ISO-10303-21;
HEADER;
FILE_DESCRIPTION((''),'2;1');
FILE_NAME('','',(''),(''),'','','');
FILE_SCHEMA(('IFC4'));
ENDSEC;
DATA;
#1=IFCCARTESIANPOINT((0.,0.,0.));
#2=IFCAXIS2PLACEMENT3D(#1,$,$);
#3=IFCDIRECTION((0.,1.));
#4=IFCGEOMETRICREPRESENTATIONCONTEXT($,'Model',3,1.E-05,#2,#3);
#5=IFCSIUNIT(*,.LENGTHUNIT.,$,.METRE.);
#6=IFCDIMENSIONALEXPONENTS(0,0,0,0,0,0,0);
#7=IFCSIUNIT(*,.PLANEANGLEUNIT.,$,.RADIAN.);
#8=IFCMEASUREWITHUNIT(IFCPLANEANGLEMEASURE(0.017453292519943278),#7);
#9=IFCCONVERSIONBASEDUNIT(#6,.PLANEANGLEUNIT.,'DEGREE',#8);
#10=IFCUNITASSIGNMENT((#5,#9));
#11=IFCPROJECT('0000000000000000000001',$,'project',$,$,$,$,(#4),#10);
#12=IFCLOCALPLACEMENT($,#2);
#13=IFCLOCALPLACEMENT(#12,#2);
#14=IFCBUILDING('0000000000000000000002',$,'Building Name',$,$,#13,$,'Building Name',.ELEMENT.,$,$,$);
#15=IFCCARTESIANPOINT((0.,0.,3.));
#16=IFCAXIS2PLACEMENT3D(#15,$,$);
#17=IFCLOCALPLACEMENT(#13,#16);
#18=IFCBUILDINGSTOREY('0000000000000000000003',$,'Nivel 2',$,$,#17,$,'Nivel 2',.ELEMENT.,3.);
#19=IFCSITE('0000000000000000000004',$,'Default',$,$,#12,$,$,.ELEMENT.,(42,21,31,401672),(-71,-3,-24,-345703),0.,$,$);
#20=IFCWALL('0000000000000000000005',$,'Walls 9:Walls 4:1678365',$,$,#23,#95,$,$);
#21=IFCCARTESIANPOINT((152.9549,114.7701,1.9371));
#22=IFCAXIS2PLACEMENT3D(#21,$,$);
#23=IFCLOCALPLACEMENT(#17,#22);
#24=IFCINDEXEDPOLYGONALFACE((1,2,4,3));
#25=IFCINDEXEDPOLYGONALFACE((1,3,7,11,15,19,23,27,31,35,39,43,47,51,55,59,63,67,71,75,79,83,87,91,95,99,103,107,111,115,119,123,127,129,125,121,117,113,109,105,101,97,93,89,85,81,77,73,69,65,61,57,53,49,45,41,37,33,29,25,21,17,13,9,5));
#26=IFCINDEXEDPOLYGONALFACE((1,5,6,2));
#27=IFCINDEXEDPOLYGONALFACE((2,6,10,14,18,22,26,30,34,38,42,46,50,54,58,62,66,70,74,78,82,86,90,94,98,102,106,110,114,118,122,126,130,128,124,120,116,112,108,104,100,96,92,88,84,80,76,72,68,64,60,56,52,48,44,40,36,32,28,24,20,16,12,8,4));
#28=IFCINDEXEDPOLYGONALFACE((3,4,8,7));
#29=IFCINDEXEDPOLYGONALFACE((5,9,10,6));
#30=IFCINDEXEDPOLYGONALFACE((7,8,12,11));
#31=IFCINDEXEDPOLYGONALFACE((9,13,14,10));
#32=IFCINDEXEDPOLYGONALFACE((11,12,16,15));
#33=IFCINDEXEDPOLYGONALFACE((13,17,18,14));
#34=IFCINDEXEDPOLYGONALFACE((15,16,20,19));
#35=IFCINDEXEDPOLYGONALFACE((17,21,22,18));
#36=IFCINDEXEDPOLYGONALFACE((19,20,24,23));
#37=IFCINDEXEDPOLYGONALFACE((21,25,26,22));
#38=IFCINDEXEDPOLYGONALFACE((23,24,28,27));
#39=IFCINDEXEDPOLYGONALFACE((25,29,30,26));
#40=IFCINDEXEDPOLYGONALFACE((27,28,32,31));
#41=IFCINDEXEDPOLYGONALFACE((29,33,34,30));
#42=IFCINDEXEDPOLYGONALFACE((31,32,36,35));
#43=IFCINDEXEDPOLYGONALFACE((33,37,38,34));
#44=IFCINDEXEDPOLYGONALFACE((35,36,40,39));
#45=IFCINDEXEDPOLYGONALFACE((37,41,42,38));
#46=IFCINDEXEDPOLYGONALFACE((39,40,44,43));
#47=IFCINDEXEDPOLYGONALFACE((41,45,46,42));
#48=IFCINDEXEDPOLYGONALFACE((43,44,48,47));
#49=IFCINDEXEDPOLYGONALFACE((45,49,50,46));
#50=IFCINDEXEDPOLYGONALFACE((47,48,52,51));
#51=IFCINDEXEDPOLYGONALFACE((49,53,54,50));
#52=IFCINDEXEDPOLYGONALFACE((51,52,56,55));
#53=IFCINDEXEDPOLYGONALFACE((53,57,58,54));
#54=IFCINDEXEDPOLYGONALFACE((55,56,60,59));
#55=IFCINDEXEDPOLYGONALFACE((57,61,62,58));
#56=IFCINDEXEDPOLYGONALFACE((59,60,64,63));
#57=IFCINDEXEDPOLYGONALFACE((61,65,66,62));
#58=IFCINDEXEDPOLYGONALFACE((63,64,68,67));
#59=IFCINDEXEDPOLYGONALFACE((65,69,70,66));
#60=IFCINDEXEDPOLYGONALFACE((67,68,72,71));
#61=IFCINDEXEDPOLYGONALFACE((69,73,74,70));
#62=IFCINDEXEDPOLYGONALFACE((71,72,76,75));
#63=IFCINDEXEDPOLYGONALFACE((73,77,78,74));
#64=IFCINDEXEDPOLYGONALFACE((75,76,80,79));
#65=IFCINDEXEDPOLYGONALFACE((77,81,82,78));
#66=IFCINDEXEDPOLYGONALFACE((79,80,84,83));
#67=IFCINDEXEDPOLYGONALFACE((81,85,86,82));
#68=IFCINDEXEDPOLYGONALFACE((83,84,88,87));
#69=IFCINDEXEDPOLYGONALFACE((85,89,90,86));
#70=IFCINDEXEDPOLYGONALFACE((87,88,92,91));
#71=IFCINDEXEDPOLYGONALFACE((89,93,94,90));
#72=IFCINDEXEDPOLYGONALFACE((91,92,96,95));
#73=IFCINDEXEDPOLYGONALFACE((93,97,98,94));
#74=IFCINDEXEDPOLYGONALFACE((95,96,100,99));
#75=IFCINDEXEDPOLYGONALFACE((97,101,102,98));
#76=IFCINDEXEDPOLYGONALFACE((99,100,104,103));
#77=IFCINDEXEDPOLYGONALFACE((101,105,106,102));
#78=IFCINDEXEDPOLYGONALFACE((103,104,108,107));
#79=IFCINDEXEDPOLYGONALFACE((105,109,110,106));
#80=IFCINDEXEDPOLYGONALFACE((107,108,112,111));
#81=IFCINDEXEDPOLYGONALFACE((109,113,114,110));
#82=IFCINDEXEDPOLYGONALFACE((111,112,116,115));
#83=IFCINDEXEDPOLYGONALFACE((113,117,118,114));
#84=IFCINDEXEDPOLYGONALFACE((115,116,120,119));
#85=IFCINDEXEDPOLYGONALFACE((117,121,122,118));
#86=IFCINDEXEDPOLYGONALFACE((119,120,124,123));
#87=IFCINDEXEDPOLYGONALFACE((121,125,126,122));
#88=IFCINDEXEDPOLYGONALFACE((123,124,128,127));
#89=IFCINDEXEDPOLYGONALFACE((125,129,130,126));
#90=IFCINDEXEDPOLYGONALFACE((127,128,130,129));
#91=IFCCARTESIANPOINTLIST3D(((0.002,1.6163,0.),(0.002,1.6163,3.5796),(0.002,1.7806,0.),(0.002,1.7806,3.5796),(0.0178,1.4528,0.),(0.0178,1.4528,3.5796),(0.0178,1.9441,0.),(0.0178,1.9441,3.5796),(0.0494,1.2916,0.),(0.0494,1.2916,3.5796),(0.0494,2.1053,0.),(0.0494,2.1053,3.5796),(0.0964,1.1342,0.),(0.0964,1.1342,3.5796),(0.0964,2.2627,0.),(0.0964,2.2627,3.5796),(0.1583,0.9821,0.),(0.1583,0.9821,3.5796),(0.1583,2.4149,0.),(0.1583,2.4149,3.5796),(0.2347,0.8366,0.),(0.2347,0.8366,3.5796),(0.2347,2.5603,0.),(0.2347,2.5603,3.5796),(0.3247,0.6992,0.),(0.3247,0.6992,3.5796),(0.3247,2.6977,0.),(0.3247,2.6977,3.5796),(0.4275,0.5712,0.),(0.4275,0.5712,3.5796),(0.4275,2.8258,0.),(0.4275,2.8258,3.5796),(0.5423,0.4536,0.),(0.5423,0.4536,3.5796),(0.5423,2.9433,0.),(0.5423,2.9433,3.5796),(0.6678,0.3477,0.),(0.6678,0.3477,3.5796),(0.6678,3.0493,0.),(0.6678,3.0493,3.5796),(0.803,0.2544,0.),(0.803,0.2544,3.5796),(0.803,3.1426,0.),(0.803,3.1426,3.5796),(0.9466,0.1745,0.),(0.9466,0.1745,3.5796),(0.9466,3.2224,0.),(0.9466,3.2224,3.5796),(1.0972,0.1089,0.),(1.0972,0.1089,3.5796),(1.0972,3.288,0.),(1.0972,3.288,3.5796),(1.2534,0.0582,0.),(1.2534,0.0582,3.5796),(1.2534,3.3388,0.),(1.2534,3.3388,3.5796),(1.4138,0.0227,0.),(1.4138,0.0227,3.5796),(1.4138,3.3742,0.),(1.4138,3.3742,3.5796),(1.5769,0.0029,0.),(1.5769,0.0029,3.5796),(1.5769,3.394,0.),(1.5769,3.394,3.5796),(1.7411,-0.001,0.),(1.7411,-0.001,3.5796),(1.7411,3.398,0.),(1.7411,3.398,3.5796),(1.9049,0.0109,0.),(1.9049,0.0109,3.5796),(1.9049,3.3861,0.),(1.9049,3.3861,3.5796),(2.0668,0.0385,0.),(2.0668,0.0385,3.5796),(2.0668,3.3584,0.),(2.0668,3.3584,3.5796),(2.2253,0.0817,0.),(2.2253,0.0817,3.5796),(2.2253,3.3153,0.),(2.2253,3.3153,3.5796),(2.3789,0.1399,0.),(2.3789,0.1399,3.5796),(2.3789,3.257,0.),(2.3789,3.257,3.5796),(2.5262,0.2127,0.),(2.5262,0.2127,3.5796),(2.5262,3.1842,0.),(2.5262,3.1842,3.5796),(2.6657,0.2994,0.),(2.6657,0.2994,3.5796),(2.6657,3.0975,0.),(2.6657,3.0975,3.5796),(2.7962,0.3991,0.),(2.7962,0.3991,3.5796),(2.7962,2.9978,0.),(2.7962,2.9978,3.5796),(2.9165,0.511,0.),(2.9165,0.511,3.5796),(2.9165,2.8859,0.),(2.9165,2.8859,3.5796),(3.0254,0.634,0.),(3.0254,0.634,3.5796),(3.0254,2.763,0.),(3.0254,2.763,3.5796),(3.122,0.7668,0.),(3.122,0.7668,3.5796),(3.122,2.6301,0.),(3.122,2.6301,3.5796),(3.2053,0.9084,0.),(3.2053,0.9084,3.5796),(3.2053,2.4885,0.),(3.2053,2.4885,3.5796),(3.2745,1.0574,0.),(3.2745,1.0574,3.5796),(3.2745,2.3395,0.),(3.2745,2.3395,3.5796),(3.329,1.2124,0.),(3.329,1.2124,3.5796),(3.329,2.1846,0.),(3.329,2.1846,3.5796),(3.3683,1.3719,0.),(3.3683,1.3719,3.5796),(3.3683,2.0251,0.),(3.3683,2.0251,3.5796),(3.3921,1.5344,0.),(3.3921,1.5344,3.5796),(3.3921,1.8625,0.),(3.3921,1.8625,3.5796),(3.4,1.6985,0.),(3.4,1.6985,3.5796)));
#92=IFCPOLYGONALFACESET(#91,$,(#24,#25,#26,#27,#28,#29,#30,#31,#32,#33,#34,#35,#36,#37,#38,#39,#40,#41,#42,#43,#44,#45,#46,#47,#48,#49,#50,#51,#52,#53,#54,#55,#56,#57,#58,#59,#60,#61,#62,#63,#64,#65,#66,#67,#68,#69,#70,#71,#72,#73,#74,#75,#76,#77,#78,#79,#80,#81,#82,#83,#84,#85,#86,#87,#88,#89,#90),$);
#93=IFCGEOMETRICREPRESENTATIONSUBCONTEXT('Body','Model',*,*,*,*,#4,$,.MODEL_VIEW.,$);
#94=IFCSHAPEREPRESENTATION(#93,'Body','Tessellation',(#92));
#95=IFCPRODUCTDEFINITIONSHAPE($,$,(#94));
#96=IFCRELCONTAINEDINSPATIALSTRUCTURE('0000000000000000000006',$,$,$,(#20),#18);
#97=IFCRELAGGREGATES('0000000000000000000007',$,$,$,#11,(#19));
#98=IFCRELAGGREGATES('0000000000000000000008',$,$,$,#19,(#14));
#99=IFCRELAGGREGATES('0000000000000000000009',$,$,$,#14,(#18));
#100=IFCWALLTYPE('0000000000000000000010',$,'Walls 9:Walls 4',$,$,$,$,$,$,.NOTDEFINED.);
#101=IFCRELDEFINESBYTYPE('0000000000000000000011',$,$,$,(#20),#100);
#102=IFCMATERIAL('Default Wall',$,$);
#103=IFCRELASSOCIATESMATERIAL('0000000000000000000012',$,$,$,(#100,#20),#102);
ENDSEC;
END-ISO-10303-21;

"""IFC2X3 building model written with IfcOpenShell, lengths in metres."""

from ifc_helpers import new_model, entity, si_unit, converted_unit, direction, frame, frame_2d, origin, place, context, subcontext, project, spatial, circle, extrude, material, type_object, element, save


model = new_model("IFC2X3")

# Units and contexts
model_context = context("Model", 3, precision=1e-05, world=origin(), true_north=direction((0.0, 1.0)))
body_context = subcontext(model_context, "Body", "Model", "MODEL_VIEW")
ifc_project = project(units=[si_unit("LENGTHUNIT", "METRE"), converted_unit("PLANEANGLEUNIT", "DEGREE", entity("IfcPlaneAngleMeasure", 0.017453292519943278), si_unit("PLANEANGLEUNIT", "RADIAN"), dimensions=[0, 0, 0, 0, 0, 0, 0])], contexts=[model_context])

# Site, building, storey
site_placement = place(None, origin())
site = spatial("IfcSite", under=ifc_project, at=site_placement, Name="Default", CompositionType="ELEMENT", RefLatitude=(42, 21, 31, 401672), RefLongitude=(-71, -3, -24, -345703), RefElevation=0.0)
building_placement = place(site_placement, origin())
building = spatial("IfcBuilding", under=site, at=building_placement, Name="Building Name", LongName="Building Name", CompositionType="ELEMENT")
storey_placement = place(building_placement, frame((0.0, 0.0, 3.0)))
storey = spatial("IfcBuildingStorey", under=building, at=storey_placement, Name="Nivel 2", LongName="Nivel 2", CompositionType="ELEMENT", Elevation=3.0)

# Wall
ifc_material_1 = material(Name="Default Wall")
wall_type_1 = type_object("IfcWallType", Name="Walls 9:Walls 4", PredefinedType="NOTDEFINED", material=ifc_material_1)
wall_1_placement = place(storey_placement, frame((152.9549, 114.7701, 1.9371)))
element("IfcWall", 1, at=wall_1_placement, inside=storey, type_object=wall_type_1, material=ifc_material_1, Name="Walls 9:Walls 4:1678365", context=body_context, shape_type="SweptSolid", body=[
    extrude(circle(Radius=1.7, at=frame_2d((0.0, 0.0), x_axis=(1.0, 0.0))), frame((1.7, 1.6985, 0.0)), (0.0, 0.0, 1.0), 3.5796),
])

save(model, "model.ifc")
